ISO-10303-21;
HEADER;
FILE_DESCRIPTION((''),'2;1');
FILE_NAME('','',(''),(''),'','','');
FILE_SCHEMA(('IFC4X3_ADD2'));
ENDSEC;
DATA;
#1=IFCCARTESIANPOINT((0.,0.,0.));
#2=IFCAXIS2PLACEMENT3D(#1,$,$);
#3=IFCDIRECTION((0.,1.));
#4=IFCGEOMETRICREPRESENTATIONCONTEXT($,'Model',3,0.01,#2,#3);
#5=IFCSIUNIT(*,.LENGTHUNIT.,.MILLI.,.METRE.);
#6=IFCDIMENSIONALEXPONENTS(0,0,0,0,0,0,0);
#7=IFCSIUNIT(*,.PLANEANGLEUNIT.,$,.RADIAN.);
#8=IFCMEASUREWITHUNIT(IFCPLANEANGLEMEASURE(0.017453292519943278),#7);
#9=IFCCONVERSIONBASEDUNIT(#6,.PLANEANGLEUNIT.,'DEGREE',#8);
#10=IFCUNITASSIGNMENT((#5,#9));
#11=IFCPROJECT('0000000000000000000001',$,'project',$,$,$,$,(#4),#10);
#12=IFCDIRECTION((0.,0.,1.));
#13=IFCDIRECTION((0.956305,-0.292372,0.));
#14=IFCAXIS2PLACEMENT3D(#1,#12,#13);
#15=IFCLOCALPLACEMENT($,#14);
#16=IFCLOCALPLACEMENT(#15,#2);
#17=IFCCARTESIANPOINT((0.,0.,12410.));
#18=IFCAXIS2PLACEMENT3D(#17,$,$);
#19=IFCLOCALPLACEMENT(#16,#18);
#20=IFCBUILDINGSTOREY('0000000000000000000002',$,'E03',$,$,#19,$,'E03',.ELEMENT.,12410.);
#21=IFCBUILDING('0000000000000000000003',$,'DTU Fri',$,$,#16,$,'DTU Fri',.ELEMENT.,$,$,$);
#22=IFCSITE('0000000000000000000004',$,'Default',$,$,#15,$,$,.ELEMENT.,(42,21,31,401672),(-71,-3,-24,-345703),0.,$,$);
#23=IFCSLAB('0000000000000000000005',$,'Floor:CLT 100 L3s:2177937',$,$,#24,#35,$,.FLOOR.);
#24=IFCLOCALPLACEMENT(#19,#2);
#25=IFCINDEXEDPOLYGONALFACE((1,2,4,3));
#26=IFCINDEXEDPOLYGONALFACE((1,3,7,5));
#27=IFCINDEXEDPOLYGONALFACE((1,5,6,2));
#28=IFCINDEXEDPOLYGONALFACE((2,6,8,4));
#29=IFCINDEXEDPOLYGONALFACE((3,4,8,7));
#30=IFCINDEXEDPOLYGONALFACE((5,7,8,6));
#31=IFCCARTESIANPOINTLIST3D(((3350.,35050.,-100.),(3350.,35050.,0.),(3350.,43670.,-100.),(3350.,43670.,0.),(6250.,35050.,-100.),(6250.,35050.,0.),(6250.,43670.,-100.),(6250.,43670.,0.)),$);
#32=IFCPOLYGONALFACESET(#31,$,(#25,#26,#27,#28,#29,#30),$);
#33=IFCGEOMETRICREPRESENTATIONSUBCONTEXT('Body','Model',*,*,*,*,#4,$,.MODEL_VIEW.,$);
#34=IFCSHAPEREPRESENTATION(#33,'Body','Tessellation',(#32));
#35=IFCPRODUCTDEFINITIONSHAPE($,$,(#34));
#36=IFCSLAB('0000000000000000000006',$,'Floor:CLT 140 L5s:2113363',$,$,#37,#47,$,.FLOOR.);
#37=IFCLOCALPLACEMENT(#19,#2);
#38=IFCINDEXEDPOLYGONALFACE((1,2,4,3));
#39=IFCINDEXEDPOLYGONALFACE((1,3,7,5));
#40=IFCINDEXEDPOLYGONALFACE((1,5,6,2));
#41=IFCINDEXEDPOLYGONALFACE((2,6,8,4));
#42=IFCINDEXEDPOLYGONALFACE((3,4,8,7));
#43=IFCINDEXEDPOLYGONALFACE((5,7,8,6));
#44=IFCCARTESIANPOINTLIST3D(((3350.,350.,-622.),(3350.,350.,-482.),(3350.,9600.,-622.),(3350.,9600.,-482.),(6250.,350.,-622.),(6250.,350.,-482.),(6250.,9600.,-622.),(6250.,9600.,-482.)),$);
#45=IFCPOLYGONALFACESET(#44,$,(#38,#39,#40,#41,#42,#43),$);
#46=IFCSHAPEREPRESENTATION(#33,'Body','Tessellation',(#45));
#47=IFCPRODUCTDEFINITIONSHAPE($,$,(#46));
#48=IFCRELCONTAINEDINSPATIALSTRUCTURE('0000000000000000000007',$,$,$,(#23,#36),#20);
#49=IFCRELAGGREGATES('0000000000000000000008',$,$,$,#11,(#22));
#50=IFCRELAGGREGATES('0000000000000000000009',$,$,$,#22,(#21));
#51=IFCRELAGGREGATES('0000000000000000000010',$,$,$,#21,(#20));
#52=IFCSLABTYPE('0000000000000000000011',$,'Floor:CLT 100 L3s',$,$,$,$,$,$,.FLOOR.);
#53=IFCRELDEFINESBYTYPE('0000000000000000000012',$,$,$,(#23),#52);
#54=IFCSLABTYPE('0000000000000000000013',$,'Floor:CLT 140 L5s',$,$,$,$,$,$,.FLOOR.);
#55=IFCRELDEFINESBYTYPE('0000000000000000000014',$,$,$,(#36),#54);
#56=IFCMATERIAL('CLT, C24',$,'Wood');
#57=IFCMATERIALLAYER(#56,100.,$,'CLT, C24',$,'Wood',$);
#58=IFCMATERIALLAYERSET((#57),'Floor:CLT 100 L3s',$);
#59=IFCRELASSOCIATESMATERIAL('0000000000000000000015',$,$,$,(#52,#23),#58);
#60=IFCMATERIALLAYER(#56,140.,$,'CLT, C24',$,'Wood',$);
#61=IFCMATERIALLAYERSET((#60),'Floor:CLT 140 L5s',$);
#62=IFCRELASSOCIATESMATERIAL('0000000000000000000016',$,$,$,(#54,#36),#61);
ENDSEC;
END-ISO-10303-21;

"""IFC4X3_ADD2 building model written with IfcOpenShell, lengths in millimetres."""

from ifc_helpers import new_model, entity, si_unit, converted_unit, direction, frame, frame_2d, origin, place, context, subcontext, project, spatial, rectangle, extrude, material, layer, layer_set, layer_usage, type_object, element, save


model = new_model("IFC4X3_ADD2")

# Units and contexts
model_context = context("Model", 3, precision=0.01, world=origin(), true_north=direction((0.0, 1.0)))
body_context = subcontext(model_context, "Body", "Model", "MODEL_VIEW")
ifc_project = project(units=[si_unit("LENGTHUNIT", "METRE", prefix="MILLI"), converted_unit("PLANEANGLEUNIT", "DEGREE", entity("IfcPlaneAngleMeasure", 0.017453292519943278), si_unit("PLANEANGLEUNIT", "RADIAN"), dimensions=[0, 0, 0, 0, 0, 0, 0])], contexts=[model_context])

# Site, building, storey
site_placement = place(None, frame((0.0, 0.0, 0.0), z_axis=(0.0, 0.0, 1.0), x_axis=(0.956305, -0.292372, 0.0)))
site = spatial("IfcSite", under=ifc_project, at=site_placement, Name="Default", CompositionType="ELEMENT", RefLatitude=(42, 21, 31, 401672), RefLongitude=(-71, -3, -24, -345703), RefElevation=0.0)
building_placement = place(site_placement, origin())
building = spatial("IfcBuilding", under=site, at=building_placement, Name="DTU Fri", LongName="DTU Fri", CompositionType="ELEMENT")
storey_placement = place(building_placement, frame((0.0, 0.0, 12410.0)))
storey = spatial("IfcBuildingStorey", under=building, at=storey_placement, Name="E03", LongName="E03", CompositionType="ELEMENT", Elevation=12410.0)

# Slabs
ifc_material = material(Name="CLT, C24", Category="Wood")
ifc_layer_1 = layer(ifc_material, 100.0, Name="CLT, C24", Category="Wood")
ifc_layer_set_1 = layer_set([ifc_layer_1], Name="Floor:CLT 100 L3s")
slab_type_1 = type_object("IfcSlabType", Name="Floor:CLT 100 L3s", PredefinedType="FLOOR", material=ifc_layer_set_1)
ifc_layer_usage_1 = layer_usage(ifc_layer_set_1, "AXIS3", "POSITIVE", 0.0)
slab_1_placement = place(storey_placement, origin())
element("IfcSlab", 1, at=slab_1_placement, inside=storey, type_object=slab_type_1, material=ifc_layer_usage_1, Name="Floor:CLT 100 L3s:2177937", PredefinedType="FLOOR", context=body_context, shape_type="SweptSolid", body=[
    extrude(rectangle(XDim=8620.0, YDim=2900.0, at=frame_2d((0.0, 0.0), x_axis=(1.0, 0.0))), frame((4800.0, 39360.0, 0.0), z_axis=(0.0, 0.0, -1.0), x_axis=(0.0, 1.0, 0.0)), (0.0, 0.0, 1.0), 100.0),
])
ifc_layer_2 = layer(ifc_material, 140.0, Name="CLT, C24", Category="Wood")
ifc_layer_set_2 = layer_set([ifc_layer_2], Name="Floor:CLT 140 L5s")
ifc_layer_usage_2 = layer_usage(ifc_layer_set_2, "AXIS3", "POSITIVE", 0.0)
slab_type_2 = type_object("IfcSlabType", Name="Floor:CLT 140 L5s", PredefinedType="FLOOR", material=ifc_layer_set_2)
slab_2_placement = place(storey_placement, origin())
element("IfcSlab", 2, at=slab_2_placement, inside=storey, type_object=slab_type_2, material=ifc_layer_usage_2, Name="Floor:CLT 140 L5s:2113363", PredefinedType="FLOOR", context=body_context, shape_type="SweptSolid", body=[
    extrude(rectangle(XDim=9250.0, YDim=2900.0, at=frame_2d((0.0, 0.0), x_axis=(1.0, 0.0))), frame((4800.0, 4975.0, -482.0), z_axis=(0.0, 0.0, -1.0), x_axis=(0.0, 1.0, 0.0)), (0.0, 0.0, 1.0), 140.0),
])

save(model, "model.ifc")
